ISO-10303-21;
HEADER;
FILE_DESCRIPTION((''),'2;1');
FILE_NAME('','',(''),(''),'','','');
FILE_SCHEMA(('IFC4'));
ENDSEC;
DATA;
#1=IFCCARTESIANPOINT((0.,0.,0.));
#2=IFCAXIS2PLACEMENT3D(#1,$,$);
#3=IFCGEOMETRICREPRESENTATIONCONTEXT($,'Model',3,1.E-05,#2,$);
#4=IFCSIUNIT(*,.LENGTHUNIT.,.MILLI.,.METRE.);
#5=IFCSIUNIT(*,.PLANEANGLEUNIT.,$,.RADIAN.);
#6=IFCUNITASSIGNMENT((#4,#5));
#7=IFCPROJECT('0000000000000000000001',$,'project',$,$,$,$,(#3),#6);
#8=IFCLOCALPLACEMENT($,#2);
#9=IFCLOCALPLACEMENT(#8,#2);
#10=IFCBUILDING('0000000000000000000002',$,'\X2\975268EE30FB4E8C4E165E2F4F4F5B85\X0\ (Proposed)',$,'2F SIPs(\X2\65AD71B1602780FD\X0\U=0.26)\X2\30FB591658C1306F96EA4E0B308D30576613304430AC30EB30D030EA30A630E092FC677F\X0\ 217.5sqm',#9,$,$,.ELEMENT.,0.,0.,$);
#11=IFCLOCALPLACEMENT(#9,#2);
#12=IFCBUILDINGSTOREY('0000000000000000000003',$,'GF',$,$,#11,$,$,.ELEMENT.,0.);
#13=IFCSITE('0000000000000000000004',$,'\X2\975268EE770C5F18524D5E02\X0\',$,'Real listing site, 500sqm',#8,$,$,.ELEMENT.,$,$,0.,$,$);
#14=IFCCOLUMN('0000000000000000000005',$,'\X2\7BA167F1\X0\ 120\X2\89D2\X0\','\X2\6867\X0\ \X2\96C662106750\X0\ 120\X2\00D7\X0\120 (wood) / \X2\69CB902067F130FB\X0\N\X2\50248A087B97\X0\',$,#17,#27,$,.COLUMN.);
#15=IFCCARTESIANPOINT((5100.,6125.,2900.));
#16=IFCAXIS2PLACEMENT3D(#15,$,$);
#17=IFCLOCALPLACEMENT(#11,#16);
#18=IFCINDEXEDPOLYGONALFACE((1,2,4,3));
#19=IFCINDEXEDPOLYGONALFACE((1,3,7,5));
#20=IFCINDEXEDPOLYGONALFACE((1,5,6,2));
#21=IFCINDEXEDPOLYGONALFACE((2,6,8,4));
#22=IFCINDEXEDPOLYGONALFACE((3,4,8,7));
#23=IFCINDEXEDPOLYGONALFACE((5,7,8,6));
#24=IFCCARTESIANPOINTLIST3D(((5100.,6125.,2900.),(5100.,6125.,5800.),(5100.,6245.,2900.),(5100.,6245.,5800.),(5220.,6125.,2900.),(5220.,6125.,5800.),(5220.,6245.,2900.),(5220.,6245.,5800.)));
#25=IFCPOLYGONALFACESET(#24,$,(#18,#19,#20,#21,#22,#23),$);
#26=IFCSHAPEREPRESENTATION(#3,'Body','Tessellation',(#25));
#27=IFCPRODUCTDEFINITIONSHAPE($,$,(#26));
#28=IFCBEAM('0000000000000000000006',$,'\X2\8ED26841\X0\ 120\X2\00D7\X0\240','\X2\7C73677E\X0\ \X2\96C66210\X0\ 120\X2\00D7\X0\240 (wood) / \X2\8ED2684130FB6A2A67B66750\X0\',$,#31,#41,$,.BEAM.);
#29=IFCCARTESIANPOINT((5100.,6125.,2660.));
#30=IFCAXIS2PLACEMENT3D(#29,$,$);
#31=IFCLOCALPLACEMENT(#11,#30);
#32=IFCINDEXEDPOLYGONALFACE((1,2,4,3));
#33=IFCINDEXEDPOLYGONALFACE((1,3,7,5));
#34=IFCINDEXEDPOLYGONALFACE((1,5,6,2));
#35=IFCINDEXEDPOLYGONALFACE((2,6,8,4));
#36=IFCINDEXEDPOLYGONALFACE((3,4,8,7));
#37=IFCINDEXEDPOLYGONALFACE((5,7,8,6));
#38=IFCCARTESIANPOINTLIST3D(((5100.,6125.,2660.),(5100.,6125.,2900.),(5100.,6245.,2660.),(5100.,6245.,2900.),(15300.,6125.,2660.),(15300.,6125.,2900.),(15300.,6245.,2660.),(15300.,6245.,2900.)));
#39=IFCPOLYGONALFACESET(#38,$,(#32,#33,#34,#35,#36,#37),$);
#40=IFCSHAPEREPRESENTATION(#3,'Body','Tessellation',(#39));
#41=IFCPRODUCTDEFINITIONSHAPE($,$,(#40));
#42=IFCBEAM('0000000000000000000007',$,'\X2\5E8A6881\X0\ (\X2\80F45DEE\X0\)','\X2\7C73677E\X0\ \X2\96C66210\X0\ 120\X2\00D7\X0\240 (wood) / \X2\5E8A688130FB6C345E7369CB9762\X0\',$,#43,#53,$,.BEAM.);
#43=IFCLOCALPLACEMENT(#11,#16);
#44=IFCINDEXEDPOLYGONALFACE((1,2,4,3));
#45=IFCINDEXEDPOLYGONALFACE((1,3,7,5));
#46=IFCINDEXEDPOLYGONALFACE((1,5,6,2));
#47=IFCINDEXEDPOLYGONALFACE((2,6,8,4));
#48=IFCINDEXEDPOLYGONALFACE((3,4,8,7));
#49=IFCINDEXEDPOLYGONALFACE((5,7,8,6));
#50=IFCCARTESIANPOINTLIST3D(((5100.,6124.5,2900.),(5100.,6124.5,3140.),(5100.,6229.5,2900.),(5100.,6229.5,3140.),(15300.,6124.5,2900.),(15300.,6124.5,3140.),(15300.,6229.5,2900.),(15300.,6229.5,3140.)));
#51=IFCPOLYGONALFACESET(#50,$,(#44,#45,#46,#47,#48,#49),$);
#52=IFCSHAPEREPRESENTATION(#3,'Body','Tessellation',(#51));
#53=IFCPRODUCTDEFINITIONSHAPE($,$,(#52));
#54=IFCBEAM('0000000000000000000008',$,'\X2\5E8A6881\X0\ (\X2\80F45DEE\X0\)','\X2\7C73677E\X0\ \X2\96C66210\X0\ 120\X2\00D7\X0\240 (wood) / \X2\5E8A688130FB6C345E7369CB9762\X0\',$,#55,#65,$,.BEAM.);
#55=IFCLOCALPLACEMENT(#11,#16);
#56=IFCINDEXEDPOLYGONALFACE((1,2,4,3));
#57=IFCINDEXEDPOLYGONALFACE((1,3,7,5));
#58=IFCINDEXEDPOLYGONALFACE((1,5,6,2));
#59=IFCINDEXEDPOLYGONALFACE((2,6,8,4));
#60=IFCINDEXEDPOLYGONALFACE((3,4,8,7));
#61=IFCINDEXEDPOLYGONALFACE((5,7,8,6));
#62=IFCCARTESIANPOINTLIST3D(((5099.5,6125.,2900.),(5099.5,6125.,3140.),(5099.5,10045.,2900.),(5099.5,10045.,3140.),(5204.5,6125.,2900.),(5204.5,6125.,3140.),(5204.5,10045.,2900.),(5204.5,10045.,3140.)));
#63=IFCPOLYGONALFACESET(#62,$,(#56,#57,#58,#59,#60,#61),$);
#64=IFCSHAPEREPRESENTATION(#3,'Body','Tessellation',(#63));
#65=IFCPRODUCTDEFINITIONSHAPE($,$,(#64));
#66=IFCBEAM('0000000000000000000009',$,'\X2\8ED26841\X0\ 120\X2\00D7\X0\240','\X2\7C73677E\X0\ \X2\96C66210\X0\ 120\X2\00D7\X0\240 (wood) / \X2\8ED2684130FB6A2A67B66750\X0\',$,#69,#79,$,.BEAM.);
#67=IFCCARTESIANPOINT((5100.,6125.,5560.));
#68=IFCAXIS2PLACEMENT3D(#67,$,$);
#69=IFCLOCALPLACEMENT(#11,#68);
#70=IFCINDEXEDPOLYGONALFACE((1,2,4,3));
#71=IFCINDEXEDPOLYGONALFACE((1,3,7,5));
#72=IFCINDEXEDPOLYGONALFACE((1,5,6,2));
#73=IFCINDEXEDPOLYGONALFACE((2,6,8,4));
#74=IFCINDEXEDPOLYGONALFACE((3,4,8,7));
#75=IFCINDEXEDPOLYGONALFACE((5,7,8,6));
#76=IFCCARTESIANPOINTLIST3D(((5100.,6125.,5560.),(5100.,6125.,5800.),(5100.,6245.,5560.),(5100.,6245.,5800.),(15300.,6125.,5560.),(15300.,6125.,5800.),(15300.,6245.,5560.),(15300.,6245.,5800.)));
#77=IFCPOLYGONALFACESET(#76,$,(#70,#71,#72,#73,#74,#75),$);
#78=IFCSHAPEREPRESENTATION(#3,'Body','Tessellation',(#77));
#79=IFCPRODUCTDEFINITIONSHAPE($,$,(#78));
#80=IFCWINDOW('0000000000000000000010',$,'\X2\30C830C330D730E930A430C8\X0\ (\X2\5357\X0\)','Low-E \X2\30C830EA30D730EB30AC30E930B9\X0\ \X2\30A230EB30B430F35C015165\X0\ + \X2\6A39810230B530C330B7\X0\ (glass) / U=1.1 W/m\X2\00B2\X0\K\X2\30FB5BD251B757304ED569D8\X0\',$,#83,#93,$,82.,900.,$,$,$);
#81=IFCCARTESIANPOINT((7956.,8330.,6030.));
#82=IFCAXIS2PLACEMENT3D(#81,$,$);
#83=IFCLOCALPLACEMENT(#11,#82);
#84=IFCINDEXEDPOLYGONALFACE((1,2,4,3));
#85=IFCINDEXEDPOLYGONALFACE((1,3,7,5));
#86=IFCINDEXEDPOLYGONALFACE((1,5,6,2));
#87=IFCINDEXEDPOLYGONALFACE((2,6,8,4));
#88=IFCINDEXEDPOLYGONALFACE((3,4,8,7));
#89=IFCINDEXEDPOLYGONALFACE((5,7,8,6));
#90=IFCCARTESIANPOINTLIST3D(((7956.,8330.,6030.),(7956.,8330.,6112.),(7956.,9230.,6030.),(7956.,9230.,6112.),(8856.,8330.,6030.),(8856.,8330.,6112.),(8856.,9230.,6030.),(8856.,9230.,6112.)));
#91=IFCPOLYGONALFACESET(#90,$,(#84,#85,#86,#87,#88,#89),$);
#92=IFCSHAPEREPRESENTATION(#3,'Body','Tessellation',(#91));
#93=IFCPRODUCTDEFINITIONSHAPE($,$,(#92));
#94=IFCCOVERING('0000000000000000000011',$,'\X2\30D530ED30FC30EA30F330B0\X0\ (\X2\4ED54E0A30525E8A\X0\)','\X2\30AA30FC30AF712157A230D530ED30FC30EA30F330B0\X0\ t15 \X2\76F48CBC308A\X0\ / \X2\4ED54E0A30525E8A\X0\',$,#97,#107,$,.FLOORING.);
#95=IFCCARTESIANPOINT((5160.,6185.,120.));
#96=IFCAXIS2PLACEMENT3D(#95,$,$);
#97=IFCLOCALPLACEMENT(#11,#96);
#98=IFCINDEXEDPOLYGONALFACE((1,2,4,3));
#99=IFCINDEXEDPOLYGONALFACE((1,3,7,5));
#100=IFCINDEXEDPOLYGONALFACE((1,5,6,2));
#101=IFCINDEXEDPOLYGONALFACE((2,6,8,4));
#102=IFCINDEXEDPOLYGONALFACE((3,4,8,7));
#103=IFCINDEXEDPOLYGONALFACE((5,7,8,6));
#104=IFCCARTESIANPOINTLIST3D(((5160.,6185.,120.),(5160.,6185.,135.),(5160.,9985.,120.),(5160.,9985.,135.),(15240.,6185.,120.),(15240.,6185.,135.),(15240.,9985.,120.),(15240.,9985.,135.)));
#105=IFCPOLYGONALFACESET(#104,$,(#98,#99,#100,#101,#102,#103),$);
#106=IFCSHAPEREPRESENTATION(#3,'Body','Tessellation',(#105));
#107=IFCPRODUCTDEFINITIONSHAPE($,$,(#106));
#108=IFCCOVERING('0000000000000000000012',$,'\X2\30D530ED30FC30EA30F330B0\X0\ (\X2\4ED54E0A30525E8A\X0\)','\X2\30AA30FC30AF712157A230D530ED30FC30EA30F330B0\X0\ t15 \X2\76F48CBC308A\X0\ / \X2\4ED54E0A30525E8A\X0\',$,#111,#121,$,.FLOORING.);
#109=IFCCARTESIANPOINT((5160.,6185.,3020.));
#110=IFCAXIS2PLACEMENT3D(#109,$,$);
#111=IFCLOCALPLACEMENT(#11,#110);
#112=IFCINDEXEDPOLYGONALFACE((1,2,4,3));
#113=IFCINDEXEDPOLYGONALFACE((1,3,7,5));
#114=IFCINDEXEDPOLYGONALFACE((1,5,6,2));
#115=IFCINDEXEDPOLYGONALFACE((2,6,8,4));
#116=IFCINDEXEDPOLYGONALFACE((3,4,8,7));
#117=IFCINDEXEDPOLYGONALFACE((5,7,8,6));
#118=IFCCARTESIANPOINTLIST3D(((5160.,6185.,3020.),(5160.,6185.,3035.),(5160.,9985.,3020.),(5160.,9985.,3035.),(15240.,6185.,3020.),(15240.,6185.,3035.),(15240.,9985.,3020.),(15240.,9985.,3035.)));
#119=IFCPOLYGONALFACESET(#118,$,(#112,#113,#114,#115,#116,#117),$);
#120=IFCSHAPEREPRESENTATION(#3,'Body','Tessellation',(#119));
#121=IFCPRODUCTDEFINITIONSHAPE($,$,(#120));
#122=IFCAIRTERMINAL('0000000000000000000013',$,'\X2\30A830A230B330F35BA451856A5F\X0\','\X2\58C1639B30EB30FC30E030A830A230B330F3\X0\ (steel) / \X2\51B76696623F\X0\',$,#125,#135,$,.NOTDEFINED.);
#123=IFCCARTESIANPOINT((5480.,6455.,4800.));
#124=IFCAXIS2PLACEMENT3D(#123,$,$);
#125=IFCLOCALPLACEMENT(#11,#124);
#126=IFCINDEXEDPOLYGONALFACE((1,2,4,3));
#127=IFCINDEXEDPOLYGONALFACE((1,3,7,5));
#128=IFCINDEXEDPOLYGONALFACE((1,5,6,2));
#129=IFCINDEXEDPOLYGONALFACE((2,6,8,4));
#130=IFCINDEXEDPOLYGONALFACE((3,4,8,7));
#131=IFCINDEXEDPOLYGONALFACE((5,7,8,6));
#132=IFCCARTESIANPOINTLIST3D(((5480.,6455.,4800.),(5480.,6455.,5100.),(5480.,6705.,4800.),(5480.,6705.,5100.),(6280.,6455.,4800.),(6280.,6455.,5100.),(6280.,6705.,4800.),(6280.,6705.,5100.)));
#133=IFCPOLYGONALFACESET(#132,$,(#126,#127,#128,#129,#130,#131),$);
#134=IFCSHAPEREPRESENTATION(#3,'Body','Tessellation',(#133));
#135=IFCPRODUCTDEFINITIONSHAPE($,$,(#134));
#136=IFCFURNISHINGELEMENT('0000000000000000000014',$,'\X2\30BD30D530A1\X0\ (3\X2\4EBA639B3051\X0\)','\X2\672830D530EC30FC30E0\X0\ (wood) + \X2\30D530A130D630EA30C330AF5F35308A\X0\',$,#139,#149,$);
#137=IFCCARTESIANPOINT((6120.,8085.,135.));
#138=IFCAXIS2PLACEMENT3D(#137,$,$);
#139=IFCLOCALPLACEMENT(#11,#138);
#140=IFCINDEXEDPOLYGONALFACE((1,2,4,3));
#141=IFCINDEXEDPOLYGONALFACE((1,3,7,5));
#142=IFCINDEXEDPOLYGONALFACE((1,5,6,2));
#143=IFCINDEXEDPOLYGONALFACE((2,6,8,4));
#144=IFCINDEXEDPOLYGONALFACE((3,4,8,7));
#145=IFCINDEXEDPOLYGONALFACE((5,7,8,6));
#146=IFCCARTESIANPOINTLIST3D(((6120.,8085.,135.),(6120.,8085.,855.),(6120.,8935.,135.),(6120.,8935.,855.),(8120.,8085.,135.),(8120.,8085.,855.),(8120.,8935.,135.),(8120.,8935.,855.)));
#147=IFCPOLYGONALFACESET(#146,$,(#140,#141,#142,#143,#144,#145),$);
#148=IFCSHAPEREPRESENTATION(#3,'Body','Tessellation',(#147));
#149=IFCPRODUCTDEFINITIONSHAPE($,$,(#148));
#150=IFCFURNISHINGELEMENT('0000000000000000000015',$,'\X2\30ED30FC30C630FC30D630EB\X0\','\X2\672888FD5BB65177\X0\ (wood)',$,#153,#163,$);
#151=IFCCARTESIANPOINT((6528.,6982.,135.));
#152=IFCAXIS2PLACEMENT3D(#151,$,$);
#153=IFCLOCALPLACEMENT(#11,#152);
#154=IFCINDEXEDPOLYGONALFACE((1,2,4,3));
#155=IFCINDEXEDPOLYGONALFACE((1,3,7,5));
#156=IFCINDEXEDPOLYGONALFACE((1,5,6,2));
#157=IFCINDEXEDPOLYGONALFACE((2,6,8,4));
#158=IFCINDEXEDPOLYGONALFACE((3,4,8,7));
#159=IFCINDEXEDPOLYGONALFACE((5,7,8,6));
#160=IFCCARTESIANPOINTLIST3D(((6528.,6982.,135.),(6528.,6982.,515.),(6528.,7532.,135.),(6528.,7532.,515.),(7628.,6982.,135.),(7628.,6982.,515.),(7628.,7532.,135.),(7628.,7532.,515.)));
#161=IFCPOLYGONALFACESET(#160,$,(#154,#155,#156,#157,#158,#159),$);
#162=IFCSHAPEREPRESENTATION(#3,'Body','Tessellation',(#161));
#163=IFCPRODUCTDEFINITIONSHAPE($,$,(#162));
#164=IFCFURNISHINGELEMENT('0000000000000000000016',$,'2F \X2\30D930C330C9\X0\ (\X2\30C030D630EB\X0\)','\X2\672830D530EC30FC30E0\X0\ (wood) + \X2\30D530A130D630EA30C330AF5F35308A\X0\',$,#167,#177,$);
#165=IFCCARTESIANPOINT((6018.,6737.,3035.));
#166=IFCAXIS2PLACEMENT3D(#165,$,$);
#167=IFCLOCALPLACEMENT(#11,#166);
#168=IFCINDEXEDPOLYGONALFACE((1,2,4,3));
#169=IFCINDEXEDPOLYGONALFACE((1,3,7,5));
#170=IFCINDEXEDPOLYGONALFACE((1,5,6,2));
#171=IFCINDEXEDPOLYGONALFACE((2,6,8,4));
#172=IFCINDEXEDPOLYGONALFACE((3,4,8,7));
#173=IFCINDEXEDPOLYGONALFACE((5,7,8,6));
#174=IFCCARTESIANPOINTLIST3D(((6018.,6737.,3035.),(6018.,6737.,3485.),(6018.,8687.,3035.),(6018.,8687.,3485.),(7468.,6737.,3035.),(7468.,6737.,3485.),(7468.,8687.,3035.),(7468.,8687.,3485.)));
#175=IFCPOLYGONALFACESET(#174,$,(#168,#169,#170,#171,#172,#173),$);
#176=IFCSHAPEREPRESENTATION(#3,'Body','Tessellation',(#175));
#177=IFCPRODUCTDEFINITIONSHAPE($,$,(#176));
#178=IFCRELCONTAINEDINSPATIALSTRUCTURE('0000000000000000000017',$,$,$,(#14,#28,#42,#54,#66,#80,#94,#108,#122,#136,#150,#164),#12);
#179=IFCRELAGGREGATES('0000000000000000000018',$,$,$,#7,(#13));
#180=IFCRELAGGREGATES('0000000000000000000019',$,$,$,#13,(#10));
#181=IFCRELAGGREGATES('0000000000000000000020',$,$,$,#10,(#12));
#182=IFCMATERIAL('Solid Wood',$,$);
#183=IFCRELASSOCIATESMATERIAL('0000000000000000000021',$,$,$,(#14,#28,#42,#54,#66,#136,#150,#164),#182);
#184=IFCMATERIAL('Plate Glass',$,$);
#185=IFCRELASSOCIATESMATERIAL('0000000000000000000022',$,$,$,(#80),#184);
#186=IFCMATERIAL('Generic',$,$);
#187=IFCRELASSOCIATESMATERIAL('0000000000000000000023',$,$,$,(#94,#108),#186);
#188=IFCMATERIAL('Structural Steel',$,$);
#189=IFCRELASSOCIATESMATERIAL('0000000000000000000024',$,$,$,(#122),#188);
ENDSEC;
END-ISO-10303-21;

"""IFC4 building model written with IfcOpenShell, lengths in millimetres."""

from ifc_helpers import new_model, si_unit, frame, frame_2d, origin, place, context, project, spatial, rectangle, extrude, material, element, save


model = new_model("IFC4")

# Units and contexts
model_context = context("Model", 3, precision=1e-05, world=origin())
ifc_project = project(units=[si_unit("LENGTHUNIT", "METRE", prefix="MILLI"), si_unit("PLANEANGLEUNIT", "RADIAN")], contexts=[model_context])

# Site, building, storey
site_placement = place(None, origin())
site = spatial("IfcSite", under=ifc_project, at=site_placement, Name="青森県弘前市", ObjectType="Real listing site, 500sqm", CompositionType="ELEMENT", RefElevation=0.0)
building_placement = place(site_placement, origin())
building = spatial("IfcBuilding", under=site, at=building_placement, Name="青森・二世帯住宅 (Proposed)", ObjectType="2F SIPs(断熱性能U=0.26)・外壁は雪下ろし易いガルバリウム鋼板 217.5sqm", CompositionType="ELEMENT", ElevationOfRefHeight=0.0, ElevationOfTerrain=0.0)
storey_placement = place(building_placement, origin())
storey = spatial("IfcBuildingStorey", under=building, at=storey_placement, Name="GF", CompositionType="ELEMENT", Elevation=0.0)

# Column
ifc_material_1 = material(Name="Solid Wood")
column_1_placement = place(storey_placement, frame((5100.0, 6125.0, 2900.0)))
element("IfcColumn", 1, at=column_1_placement, inside=storey, material=ifc_material_1, Name="管柱 120角", Description="桧 集成材 120×120 (wood) / 構造柱・N値計算", PredefinedType="COLUMN", context=model_context, shape_type="SweptSolid", body=[
    extrude(rectangle(XDim=120.0, YDim=120.0, at=frame_2d((60.0, 60.0))), frame((5100.0, 6125.0, 2900.0)), (0.0, 0.0, 1.0), 2900.0),
])

# Beams
beam_1_placement = place(storey_placement, frame((5100.0, 6125.0, 2660.0)))
element("IfcBeam", 2, at=beam_1_placement, inside=storey, material=ifc_material_1, Name="軒桁 120×240", Description="米松 集成 120×240 (wood) / 軒桁・横架材", PredefinedType="BEAM", context=model_context, shape_type="SweptSolid", body=[
    extrude(rectangle(XDim=10200.0, YDim=120.0, at=frame_2d((5100.0, 60.0))), frame((5100.0, 6125.0, 2660.0)), (0.0, 0.0, 1.0), 240.0),
])
beam_2_placement = place(storey_placement, frame((5100.0, 6125.0, 2900.0)))
element("IfcBeam", 3, at=beam_2_placement, inside=storey, material=ifc_material_1, Name="床梁 (胴差)", Description="米松 集成 120×240 (wood) / 床梁・水平構面", PredefinedType="BEAM", context=model_context, shape_type="SweptSolid", body=[
    extrude(rectangle(XDim=10200.0, YDim=105.0, at=frame_2d((5100.0, 52.0))), frame((5100.0, 6125.0, 2900.0)), (0.0, 0.0, 1.0), 240.0),
])
beam_3_placement = place(storey_placement, frame((5100.0, 6125.0, 2900.0)))
element("IfcBeam", 4, at=beam_3_placement, inside=storey, material=ifc_material_1, Name="床梁 (胴差)", Description="米松 集成 120×240 (wood) / 床梁・水平構面", PredefinedType="BEAM", context=model_context, shape_type="SweptSolid", body=[
    extrude(rectangle(XDim=105.0, YDim=3920.0, at=frame_2d((52.0, 1960.0))), frame((5100.0, 6125.0, 2900.0)), (0.0, 0.0, 1.0), 240.0),
])
beam_4_placement = place(storey_placement, frame((5100.0, 6125.0, 5560.0)))
element("IfcBeam", 5, at=beam_4_placement, inside=storey, material=ifc_material_1, Name="軒桁 120×240", Description="米松 集成 120×240 (wood) / 軒桁・横架材", PredefinedType="BEAM", context=model_context, shape_type="SweptSolid", body=[
    extrude(rectangle(XDim=10200.0, YDim=120.0, at=frame_2d((5100.0, 60.0))), frame((5100.0, 6125.0, 5560.0)), (0.0, 0.0, 1.0), 240.0),
])

# Window
ifc_material_2 = material(Name="Plate Glass")
window_placement = place(storey_placement, frame((7956.0, 8330.0, 6030.0)))
element("IfcWindow", 6, at=window_placement, inside=storey, material=ifc_material_2, Name="トップライト (南)", Description="Low-E トリプルガラス アルゴン封入 + 樹脂サッシ (glass) / U=1.1 W/m²K・寒冷地仕様", OverallHeight=82.0, OverallWidth=900.0, context=model_context, shape_type="SweptSolid", body=[
    extrude(rectangle(XDim=900.0, YDim=900.0, at=frame_2d((450.0, 450.0))), frame((7956.0, 8330.0, 6030.0)), (0.0, 0.0, 1.0), 82.0),
])

# Coverings
ifc_material_3 = material(Name="Generic")
covering_1_placement = place(storey_placement, frame((5160.0, 6185.0, 120.0)))
element("IfcCovering", 7, at=covering_1_placement, inside=storey, material=ifc_material_3, Name="フローリング (仕上げ床)", Description="オーク無垢フローリング t15 直貼り / 仕上げ床", PredefinedType="FLOORING", context=model_context, shape_type="SweptSolid", body=[
    extrude(rectangle(XDim=10080.0, YDim=3800.0, at=frame_2d((5040.0, 1900.0))), frame((5160.0, 6185.0, 120.0)), (0.0, 0.0, 1.0), 15.0),
])
covering_2_placement = place(storey_placement, frame((5160.0, 6185.0, 3020.0)))
element("IfcCovering", 8, at=covering_2_placement, inside=storey, material=ifc_material_3, Name="フローリング (仕上げ床)", Description="オーク無垢フローリング t15 直貼り / 仕上げ床", PredefinedType="FLOORING", context=model_context, shape_type="SweptSolid", body=[
    extrude(rectangle(XDim=10080.0, YDim=3800.0, at=frame_2d((5040.0, 1900.0))), frame((5160.0, 6185.0, 3020.0)), (0.0, 0.0, 1.0), 15.0),
])

# Air terminal
ifc_material_4 = material(Name="Structural Steel")
air_terminal_placement = place(storey_placement, frame((5480.0, 6455.0, 4800.0)))
element("IfcAirTerminal", 9, at=air_terminal_placement, inside=storey, material=ifc_material_4, Name="エアコン室内機", Description="壁掛ルームエアコン (steel) / 冷暖房", PredefinedType="NOTDEFINED", context=model_context, shape_type="SweptSolid", body=[
    extrude(rectangle(XDim=800.0, YDim=250.0, at=frame_2d((400.0, 125.0))), frame((5480.0, 6455.0, 4800.0)), (0.0, 0.0, 1.0), 300.0),
])

# Furnishing elements
furnishing_1_placement = place(storey_placement, frame((6120.0, 8085.0, 135.0)))
element("IfcFurnishingElement", 10, at=furnishing_1_placement, inside=storey, material=ifc_material_1, Name="ソファ (3人掛け)", Description="木フレーム (wood) + ファブリック張り", context=model_context, shape_type="SweptSolid", body=[
    extrude(rectangle(XDim=2000.0, YDim=850.0, at=frame_2d((1000.0, 425.0))), frame((6120.0, 8085.0, 135.0)), (0.0, 0.0, 1.0), 720.0),
])
furnishing_2_placement = place(storey_placement, frame((6528.0, 6982.0, 135.0)))
element("IfcFurnishingElement", 11, at=furnishing_2_placement, inside=storey, material=ifc_material_1, Name="ローテーブル", Description="木製家具 (wood)", context=model_context, shape_type="SweptSolid", body=[
    extrude(rectangle(XDim=1100.0, YDim=550.0, at=frame_2d((550.0, 275.0))), frame((6528.0, 6982.0, 135.0)), (0.0, 0.0, 1.0), 380.0),
])
furnishing_3_placement = place(storey_placement, frame((6018.0, 6737.0, 3035.0)))
element("IfcFurnishingElement", 12, at=furnishing_3_placement, inside=storey, material=ifc_material_1, Name="2F ベッド (ダブル)", Description="木フレーム (wood) + ファブリック張り", context=model_context, shape_type="SweptSolid", body=[
    extrude(rectangle(XDim=1450.0, YDim=1950.0, at=frame_2d((725.0, 975.0))), frame((6018.0, 6737.0, 3035.0)), (0.0, 0.0, 1.0), 450.0),
])

save(model, "model.ifc")
